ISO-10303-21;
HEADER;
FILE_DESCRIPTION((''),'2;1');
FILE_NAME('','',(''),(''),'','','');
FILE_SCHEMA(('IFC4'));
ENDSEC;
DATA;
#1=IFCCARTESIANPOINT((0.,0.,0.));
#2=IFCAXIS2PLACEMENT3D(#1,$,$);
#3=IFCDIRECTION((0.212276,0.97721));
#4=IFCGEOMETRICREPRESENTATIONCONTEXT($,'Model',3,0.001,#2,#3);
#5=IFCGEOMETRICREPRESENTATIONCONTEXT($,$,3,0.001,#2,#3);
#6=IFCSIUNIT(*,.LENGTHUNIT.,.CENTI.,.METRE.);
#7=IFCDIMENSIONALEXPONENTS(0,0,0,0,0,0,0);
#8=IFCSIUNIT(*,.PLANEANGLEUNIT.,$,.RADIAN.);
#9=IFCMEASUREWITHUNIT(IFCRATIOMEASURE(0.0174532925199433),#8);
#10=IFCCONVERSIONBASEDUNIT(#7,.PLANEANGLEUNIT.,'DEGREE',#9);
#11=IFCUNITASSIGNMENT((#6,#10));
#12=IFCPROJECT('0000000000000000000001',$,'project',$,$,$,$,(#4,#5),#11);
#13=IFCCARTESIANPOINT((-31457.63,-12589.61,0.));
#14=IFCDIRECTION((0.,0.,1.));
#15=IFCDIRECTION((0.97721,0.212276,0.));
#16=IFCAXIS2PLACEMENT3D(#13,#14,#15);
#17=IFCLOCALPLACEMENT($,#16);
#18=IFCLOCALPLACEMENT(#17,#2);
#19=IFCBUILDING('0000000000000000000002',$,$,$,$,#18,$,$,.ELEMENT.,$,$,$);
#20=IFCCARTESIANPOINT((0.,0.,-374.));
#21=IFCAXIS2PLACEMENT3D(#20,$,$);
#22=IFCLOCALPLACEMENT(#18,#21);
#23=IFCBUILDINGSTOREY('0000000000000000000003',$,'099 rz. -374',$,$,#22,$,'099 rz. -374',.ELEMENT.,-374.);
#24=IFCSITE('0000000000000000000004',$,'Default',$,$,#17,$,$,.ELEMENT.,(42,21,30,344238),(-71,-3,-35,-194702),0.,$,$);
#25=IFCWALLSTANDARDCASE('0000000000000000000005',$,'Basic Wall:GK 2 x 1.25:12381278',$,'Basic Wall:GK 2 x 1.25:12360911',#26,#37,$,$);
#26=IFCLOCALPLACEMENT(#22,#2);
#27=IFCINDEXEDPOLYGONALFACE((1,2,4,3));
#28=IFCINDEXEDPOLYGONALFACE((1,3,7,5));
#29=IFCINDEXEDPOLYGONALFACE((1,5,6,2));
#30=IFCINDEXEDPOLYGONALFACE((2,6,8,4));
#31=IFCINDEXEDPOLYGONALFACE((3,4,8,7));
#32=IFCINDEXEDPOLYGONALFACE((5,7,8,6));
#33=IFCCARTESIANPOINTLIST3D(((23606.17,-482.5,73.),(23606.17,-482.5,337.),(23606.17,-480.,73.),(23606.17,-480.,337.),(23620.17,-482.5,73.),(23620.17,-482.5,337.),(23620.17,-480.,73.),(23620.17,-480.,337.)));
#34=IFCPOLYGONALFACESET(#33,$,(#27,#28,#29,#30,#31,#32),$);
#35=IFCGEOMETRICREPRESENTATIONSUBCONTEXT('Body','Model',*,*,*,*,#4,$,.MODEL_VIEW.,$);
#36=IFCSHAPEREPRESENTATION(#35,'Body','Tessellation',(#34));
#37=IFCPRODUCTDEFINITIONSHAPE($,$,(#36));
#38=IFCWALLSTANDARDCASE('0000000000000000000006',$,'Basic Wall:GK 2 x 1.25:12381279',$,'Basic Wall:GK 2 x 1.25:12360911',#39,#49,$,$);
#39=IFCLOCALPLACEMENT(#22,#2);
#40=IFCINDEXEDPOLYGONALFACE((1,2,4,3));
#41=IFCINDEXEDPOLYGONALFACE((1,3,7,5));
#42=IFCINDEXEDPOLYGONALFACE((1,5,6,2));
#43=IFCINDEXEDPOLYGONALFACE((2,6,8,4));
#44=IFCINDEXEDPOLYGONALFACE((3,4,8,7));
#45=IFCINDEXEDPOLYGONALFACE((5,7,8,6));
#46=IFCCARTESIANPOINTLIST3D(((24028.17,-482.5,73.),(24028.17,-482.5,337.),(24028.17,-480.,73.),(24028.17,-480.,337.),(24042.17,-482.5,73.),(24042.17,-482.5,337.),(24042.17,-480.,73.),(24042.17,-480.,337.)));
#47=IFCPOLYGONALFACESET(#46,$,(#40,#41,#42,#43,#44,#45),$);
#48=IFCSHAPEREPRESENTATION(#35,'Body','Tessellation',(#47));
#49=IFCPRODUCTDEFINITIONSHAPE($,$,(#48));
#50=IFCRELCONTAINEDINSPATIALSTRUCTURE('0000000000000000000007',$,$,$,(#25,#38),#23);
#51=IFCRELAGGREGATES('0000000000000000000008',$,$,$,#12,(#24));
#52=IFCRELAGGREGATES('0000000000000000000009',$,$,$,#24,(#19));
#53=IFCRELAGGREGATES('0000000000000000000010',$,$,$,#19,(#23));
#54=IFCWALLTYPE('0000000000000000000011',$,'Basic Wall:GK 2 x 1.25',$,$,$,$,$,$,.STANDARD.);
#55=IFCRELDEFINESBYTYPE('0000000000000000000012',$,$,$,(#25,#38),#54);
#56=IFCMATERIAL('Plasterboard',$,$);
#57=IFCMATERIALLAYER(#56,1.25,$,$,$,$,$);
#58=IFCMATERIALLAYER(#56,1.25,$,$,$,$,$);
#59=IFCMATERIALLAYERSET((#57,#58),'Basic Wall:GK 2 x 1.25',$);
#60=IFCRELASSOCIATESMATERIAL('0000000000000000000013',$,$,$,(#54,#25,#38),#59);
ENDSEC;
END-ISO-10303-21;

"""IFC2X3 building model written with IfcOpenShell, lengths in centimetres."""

from ifc_helpers import new_model, entity, si_unit, converted_unit, direction, frame, frame_2d, origin, place, context, subcontext, project, spatial, rectangle, extrude, material, layer, layer_set, layer_usage, type_object, element, save


model = new_model("IFC2X3")

# Units and contexts
model_context = context("Model", 3, precision=0.001, world=origin(), true_north=direction((0.212276, 0.97721)))
context_of_model = context(None, 3, precision=0.001, world=origin(), true_north=direction((0.212276, 0.97721)))
body_context = subcontext(model_context, "Body", "Model", "MODEL_VIEW")
ifc_project = project(units=[si_unit("LENGTHUNIT", "METRE", prefix="CENTI"), converted_unit("PLANEANGLEUNIT", "DEGREE", entity("IfcRatioMeasure", 0.0174532925199433), si_unit("PLANEANGLEUNIT", "RADIAN"), dimensions=[0, 0, 0, 0, 0, 0, 0])], contexts=[model_context, context_of_model])

# Site, building, storey
site_placement = place(None, frame((-31457.63, -12589.61, 0.0), z_axis=(0.0, 0.0, 1.0), x_axis=(0.97721, 0.212276, 0.0)))
site = spatial("IfcSite", under=ifc_project, at=site_placement, Name="Default", CompositionType="ELEMENT", RefLatitude=(42, 21, 30, 344238), RefLongitude=(-71, -3, -35, -194702), RefElevation=0.0)
building_placement = place(site_placement, origin())
building = spatial("IfcBuilding", under=site, at=building_placement, CompositionType="ELEMENT")
storey_placement = place(building_placement, frame((0.0, 0.0, -374.0)))
storey = spatial("IfcBuildingStorey", under=building, at=storey_placement, Name="099 rz. -374", LongName="099 rz. -374", CompositionType="ELEMENT", Elevation=-374.0)

# Walls
ifc_material_1 = material(Name="Plasterboard")
ifc_layer_1 = layer(ifc_material_1, 1.25)
ifc_layer_2 = layer(ifc_material_1, 1.25)
ifc_layer_set_1 = layer_set([ifc_layer_1, ifc_layer_2], Name="Basic Wall:GK 2 x 1.25")
wall_type_1 = type_object("IfcWallType", Name="Basic Wall:GK 2 x 1.25", PredefinedType="STANDARD", material=ifc_layer_set_1)
ifc_layer_usage_1 = layer_usage(ifc_layer_set_1, "AXIS2", "POSITIVE", -1.25)
wall_1_placement = place(storey_placement, frame((23606.17, -481.25, 73.0)))
element("IfcWallStandardCase", 1, at=wall_1_placement, inside=storey, type_object=wall_type_1, material=ifc_layer_usage_1, Name="Basic Wall:GK 2 x 1.25:12381278", ObjectType="Basic Wall:GK 2 x 1.25:12360911", context=body_context, shape_type="SweptSolid", body=[
    extrude(rectangle(XDim=14.0, YDim=2.5, at=frame_2d((7.0, 0.0), x_axis=(-1.0, 0.0))), origin(), (0.0, 0.0, 1.0), 264.0),
])
ifc_layer_usage_2 = layer_usage(ifc_layer_set_1, "AXIS2", "POSITIVE", -1.25)
wall_2_placement = place(storey_placement, frame((24028.17, -481.25, 73.0)))
element("IfcWallStandardCase", 2, at=wall_2_placement, inside=storey, type_object=wall_type_1, material=ifc_layer_usage_2, Name="Basic Wall:GK 2 x 1.25:12381279", ObjectType="Basic Wall:GK 2 x 1.25:12360911", context=body_context, shape_type="SweptSolid", body=[
    extrude(rectangle(XDim=14.0, YDim=2.5, at=frame_2d((7.0, 0.0), x_axis=(-1.0, 0.0))), origin(), (0.0, 0.0, 1.0), 264.0),
])

save(model, "model.ifc")
